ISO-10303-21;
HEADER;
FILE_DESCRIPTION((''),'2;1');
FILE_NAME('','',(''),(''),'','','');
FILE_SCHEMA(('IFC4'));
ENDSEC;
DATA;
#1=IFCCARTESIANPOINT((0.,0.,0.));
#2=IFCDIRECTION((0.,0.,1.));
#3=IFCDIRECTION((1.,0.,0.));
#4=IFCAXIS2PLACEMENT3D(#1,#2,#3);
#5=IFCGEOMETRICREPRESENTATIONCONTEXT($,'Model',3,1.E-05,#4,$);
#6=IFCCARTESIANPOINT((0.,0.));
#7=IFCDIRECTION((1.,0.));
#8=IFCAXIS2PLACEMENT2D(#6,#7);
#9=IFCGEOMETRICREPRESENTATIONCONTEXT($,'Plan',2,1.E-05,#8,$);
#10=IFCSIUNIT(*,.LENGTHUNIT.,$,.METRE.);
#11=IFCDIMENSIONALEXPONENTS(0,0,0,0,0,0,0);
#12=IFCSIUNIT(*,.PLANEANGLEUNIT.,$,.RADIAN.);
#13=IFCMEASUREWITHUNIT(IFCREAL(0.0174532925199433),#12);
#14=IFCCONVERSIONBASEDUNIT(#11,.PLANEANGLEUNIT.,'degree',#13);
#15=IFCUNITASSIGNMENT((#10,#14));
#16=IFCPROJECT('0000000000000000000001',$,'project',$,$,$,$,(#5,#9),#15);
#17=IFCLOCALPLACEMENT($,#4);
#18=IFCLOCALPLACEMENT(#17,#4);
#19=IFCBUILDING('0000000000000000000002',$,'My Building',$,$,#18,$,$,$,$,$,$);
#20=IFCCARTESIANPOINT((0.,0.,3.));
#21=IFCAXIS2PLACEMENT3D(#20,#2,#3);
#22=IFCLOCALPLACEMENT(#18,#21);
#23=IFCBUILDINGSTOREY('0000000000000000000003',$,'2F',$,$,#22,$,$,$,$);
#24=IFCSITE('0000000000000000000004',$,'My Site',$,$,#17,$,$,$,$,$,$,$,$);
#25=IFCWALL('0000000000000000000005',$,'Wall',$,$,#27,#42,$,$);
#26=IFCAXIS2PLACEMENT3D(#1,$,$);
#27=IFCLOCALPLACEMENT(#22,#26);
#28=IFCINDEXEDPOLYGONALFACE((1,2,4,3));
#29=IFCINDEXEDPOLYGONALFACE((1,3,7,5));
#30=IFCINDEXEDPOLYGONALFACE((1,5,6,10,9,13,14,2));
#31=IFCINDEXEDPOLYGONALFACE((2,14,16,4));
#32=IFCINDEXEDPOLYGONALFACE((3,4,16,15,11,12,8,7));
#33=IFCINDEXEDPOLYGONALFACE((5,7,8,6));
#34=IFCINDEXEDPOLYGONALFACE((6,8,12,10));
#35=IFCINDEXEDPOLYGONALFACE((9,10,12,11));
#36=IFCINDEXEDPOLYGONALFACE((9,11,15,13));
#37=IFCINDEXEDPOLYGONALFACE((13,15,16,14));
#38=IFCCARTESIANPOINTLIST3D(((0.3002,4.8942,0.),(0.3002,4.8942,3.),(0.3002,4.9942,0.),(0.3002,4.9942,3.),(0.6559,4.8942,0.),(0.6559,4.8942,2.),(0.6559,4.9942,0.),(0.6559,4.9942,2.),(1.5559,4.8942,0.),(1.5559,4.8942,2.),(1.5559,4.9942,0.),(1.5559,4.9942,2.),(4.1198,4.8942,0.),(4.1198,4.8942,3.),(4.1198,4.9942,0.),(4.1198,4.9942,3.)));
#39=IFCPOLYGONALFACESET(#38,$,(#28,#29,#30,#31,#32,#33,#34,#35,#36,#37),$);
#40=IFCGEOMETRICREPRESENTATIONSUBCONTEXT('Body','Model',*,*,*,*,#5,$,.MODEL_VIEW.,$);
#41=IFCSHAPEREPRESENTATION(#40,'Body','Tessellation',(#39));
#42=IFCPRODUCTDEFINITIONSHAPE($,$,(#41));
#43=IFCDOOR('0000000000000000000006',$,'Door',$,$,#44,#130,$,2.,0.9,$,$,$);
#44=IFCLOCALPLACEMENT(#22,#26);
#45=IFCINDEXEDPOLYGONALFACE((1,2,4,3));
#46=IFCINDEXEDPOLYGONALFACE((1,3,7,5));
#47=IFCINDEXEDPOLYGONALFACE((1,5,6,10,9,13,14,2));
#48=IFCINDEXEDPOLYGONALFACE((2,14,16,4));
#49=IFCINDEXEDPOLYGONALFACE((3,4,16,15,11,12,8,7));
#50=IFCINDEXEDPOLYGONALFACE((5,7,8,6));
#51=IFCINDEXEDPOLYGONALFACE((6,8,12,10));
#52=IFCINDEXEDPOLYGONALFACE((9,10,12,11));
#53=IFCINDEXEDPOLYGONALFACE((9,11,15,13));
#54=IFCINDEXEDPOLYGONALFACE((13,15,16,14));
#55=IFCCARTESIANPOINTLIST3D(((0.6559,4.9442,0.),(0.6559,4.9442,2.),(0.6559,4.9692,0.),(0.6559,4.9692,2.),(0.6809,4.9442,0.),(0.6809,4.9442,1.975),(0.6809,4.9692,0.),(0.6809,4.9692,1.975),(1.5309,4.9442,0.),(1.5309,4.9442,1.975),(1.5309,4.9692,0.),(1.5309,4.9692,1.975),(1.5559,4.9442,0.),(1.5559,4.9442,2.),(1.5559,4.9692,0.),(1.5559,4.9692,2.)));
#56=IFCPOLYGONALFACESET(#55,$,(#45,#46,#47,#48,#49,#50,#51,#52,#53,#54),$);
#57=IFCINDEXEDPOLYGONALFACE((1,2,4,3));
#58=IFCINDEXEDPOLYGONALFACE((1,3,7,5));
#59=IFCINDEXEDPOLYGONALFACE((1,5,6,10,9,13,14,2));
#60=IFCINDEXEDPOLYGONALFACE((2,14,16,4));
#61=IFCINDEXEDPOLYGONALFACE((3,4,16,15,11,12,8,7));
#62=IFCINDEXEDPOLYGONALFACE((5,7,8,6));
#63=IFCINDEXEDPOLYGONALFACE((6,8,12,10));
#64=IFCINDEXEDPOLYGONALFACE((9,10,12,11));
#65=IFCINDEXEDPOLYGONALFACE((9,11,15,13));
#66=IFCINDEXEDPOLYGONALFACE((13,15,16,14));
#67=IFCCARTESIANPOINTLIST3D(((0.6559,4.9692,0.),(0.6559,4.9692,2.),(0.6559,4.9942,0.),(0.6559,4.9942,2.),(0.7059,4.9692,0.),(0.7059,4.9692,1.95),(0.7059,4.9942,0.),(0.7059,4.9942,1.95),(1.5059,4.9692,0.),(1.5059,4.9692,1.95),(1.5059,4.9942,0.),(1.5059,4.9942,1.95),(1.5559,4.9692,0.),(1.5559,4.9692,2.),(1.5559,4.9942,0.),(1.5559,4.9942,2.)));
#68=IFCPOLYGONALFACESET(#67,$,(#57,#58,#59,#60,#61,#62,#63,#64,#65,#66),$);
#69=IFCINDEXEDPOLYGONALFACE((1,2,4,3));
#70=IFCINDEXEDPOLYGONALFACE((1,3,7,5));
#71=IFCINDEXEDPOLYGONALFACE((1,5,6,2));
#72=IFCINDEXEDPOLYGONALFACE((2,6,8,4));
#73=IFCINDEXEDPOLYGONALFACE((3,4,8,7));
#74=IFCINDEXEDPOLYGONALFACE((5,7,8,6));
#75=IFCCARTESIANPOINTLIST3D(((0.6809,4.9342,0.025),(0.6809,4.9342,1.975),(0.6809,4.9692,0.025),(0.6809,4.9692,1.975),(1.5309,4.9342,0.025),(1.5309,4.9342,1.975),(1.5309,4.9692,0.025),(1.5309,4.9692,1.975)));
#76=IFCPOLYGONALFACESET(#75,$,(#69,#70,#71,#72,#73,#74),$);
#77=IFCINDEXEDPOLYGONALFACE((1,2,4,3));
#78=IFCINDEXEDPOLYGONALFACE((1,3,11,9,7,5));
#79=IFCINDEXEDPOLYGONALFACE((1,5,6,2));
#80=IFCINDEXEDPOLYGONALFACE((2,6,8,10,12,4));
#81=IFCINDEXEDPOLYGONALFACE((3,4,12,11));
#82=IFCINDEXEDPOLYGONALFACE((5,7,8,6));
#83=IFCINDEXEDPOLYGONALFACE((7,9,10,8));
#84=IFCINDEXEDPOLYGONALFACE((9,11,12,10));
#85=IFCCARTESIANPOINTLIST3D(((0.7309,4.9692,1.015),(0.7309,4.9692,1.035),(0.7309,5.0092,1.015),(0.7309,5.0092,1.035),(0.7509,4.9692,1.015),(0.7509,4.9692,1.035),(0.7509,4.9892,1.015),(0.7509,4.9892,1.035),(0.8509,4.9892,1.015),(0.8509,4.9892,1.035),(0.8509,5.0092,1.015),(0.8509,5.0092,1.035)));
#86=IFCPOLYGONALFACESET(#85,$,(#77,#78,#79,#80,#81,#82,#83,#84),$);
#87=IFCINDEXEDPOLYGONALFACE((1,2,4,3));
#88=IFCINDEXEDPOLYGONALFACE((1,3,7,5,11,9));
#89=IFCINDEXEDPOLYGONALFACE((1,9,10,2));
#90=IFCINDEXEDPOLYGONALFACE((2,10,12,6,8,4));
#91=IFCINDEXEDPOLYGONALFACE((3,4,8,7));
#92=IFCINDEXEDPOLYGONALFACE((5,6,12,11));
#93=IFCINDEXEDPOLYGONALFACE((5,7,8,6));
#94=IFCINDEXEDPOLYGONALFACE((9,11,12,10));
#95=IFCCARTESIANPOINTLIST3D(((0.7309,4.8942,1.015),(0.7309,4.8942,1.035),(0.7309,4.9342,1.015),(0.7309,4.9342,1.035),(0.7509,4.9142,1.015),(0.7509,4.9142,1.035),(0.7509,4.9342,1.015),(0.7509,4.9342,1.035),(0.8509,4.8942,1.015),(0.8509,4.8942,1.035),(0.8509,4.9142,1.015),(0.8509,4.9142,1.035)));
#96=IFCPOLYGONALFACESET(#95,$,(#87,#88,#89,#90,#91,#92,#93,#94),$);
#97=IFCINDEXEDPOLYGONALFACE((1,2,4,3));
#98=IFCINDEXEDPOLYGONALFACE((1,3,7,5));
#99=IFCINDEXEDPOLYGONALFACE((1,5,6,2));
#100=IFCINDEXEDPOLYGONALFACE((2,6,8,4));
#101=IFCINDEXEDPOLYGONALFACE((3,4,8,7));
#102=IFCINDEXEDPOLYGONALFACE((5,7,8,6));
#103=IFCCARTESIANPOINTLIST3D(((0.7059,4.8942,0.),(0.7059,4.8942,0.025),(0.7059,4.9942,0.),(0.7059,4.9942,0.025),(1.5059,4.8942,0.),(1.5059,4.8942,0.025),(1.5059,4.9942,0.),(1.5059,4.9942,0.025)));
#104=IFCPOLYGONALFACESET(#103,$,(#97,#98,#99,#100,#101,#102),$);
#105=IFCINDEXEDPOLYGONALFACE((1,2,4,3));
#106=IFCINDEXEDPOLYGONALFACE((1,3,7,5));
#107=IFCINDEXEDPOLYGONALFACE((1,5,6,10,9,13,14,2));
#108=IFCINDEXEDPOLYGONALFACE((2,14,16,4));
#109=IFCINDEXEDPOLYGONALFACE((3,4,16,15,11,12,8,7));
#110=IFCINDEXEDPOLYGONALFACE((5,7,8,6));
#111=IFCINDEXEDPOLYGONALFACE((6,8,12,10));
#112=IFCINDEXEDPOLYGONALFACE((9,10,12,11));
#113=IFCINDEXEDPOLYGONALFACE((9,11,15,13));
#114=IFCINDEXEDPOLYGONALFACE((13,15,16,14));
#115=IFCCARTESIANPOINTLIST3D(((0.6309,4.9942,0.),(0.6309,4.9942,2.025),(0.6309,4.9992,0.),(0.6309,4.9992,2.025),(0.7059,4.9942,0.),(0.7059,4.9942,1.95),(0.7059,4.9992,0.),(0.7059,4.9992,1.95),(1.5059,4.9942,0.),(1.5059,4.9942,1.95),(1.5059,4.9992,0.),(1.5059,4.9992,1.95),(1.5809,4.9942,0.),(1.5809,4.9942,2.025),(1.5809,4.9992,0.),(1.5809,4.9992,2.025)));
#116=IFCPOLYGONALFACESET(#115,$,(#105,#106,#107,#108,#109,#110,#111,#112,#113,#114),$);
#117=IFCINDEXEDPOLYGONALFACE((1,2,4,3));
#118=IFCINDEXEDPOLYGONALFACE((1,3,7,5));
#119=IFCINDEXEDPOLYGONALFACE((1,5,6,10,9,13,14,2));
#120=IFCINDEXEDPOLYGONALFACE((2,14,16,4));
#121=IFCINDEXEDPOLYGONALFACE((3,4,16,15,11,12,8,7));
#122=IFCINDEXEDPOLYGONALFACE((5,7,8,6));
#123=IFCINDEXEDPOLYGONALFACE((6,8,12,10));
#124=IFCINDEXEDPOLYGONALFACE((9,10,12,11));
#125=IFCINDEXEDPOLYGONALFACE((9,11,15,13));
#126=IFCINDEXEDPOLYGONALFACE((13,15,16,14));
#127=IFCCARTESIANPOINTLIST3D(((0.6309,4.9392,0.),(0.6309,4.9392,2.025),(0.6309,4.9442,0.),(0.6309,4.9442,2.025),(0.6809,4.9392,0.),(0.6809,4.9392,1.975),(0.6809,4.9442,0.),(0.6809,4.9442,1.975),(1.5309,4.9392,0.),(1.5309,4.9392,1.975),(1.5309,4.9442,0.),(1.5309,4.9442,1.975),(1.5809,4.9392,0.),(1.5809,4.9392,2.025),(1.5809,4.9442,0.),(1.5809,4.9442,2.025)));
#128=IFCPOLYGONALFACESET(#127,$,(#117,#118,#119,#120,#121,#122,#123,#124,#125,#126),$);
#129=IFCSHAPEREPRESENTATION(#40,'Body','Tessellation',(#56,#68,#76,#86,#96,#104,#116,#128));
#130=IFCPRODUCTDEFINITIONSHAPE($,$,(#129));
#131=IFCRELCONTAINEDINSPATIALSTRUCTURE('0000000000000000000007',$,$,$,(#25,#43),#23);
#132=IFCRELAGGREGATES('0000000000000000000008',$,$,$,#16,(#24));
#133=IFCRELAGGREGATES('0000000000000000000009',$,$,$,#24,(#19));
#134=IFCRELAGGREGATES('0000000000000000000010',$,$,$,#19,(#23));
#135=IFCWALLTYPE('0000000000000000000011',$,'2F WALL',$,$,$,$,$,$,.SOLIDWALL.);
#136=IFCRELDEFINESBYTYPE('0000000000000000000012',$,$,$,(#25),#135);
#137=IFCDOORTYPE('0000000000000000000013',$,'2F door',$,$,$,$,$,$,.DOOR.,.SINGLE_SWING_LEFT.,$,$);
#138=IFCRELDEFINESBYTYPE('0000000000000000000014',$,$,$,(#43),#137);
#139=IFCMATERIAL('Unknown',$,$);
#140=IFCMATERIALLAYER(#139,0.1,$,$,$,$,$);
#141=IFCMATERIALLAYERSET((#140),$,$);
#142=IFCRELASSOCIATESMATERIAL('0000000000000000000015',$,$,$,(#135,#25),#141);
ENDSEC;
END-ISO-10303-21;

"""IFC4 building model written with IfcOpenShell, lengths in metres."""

from ifc_helpers import new_model, entity, si_unit, converted_unit, frame, origin_with_axes, origin_2d_with_axis, place, context, subcontext, project, spatial, line, indexed_curve, outline, extrude, shape, source, transform, mapped, material, layer, layer_set, layer_usage, type_object, type_shapes, element, fill, save


model = new_model("IFC4")

# Units and contexts
model_context = context("Model", 3, precision=1e-05, world=origin_with_axes())
plan_context = context("Plan", 2, precision=1e-05, world=origin_2d_with_axis())
body_context_1 = subcontext(model_context, "Body", "Model", "MODEL_VIEW")
body_context_2 = subcontext(plan_context, "Body", "Plan", "PLAN_VIEW")
ifc_project = project(units=[si_unit("LENGTHUNIT", "METRE"), converted_unit("PLANEANGLEUNIT", "degree", entity("IfcReal", 0.0174532925199433), si_unit("PLANEANGLEUNIT", "RADIAN"), dimensions=[0, 0, 0, 0, 0, 0, 0])], contexts=[model_context, plan_context])

# Site, building, storey
site_placement = place(None, origin_with_axes())
site = spatial("IfcSite", under=ifc_project, at=site_placement, Name="My Site")
building_placement = place(site_placement, origin_with_axes())
building = spatial("IfcBuilding", under=site, at=building_placement, Name="My Building")
storey_placement = place(building_placement, frame((0.0, 0.0, 3.0), z_axis=(0.0, 0.0, 1.0), x_axis=(1.0, 0.0, 0.0)))
storey = spatial("IfcBuildingStorey", under=building, at=storey_placement, Name="2F")

# Shared definitions
ifc_material = material(Name="Unknown")

# Shared definitions
ifc_layer_1 = layer(ifc_material, 0.1)
ifc_layer_set_1 = layer_set([ifc_layer_1])
wall_type = type_object("IfcWallType", Name="2F WALL", PredefinedType="SOLIDWALL", material=ifc_layer_set_1)

# Wall, opening, door
shared_shape_1 = source(origin_with_axes(), body_context_1, "Body", "SweptSolid", [
    extrude(outline(indexed_curve([(0.0, 0.0), (0.9, 0.0), (0.9, 2.0), (0.0, 2.0)], segments=[line(1, 2, 3, 4, 1)])), frame((0.0, -0.6, 0.0), z_axis=(0.0, -1.0, 0.0), x_axis=(1.0, 0.0, 0.0)), (0.0, 0.0, -1.0), 1.2),
])
door_type = type_object("IfcDoorType", Name="2F door", OperationType="SINGLE_SWING_LEFT", PredefinedType="DOOR")
shared_shape_2 = source(origin_with_axes(), body_context_1, "Body", "SweptSolid", [
    extrude(outline(indexed_curve([(0.0, 0.0), (0.0, 2.0), (0.9, 2.0), (0.9, 0.0), (0.875, 0.0), (0.875, 1.975), (0.025, 1.975), (0.025, 0.0)], segments=[line(1, 2, 3, 4, 5, 6, 7, 8, 1)])), frame((0.0, 0.025, 0.0), z_axis=(0.0, -1.0, 0.0), x_axis=(1.0, 0.0, 0.0)), (0.0, 0.0, -1.0), 0.025),
    extrude(outline(indexed_curve([(0.0, 0.0), (0.0, 2.0), (0.9, 2.0), (0.9, 0.0), (0.85, 0.0), (0.85, 1.95), (0.05, 1.95), (0.05, 0.0)], segments=[line(1, 2, 3, 4, 5, 6, 7, 8, 1)])), frame((0.0, 0.0, 0.0), z_axis=(0.0, -1.0, 0.0), x_axis=(1.0, 0.0, 0.0)), (0.0, 0.0, -1.0), 0.025),
    extrude(outline(indexed_curve([(0.0, 0.0), (0.85, 0.0), (0.85, 0.035), (0.0, 0.035)], segments=[line(1, 2, 3, 4, 1)])), frame((0.025, 0.025, 0.025), z_axis=(0.0, 0.0, 1.0), x_axis=(1.0, 0.0, 0.0)), (0.0, 0.0, 1.0), 1.95),
    extrude(outline(indexed_curve([(0.0, 0.0), (0.0, -0.04), (-0.12, -0.04), (-0.12, -0.02), (-0.02, -0.02), (-0.02, 0.0)], segments=[line(1, 2, 3, 4, 5, 6, 1)])), frame((0.825, 0.025, 1.015), z_axis=(0.0, 0.0, 1.0), x_axis=(1.0, 0.0, 0.0)), (0.0, 0.0, 1.0), 0.02),
    extrude(outline(indexed_curve([(0.0, 0.0), (0.0, 0.04), (-0.12, 0.04), (-0.12, 0.02), (-0.02, 0.02), (-0.02, 0.0)], segments=[line(1, 2, 3, 4, 5, 6, 1)])), frame((0.825, 0.06, 1.015), z_axis=(0.0, 0.0, 1.0), x_axis=(1.0, 0.0, 0.0)), (0.0, 0.0, 1.0), 0.02),
    extrude(outline(indexed_curve([(0.0, 0.0), (0.8, 0.0), (0.8, 0.1), (0.0, 0.1)], segments=[line(1, 2, 3, 4, 1)])), frame((0.05, 0.0, 0.0), z_axis=(0.0, 0.0, 1.0), x_axis=(1.0, 0.0, 0.0)), (0.0, 0.0, 1.0), 0.025),
    extrude(outline(indexed_curve([(0.0, 0.0), (0.0, 2.025), (0.95, 2.025), (0.95, 0.0), (0.875, 0.0), (0.875, 1.95), (0.075, 1.95), (0.075, 0.0)], segments=[line(1, 2, 3, 4, 5, 6, 7, 8, 1)])), frame((-0.025, -0.005, 0.0), z_axis=(0.0, -1.0, 0.0), x_axis=(1.0, 0.0, 0.0)), (0.0, 0.0, -1.0), 0.005),
    extrude(outline(indexed_curve([(0.0, 0.0), (0.0, 2.025), (0.95, 2.025), (0.95, 0.0), (0.9, 0.0), (0.9, 1.975), (0.05, 1.975), (0.05, 0.0)], segments=[line(1, 2, 3, 4, 5, 6, 7, 8, 1)])), frame((-0.025, 0.05, 0.0), z_axis=(0.0, -1.0, 0.0), x_axis=(1.0, 0.0, 0.0)), (0.0, 0.0, -1.0), 0.005),
])
shared_shape_3 = source(origin_with_axes(), body_context_2, "Body", "Curve2D", [
    entity("IfcIndexedPolyCurve", entity("IfcCartesianPointList2D", [[0.0, 0.0], [0.0, 0.05], [0.025, 0.05], [0.025, 0.025], [0.05, 0.025], [0.05, 0.0]]), [entity("IfcLineIndex", [1, 2, 3, 4, 5, 6, 1])]),
    entity("IfcIndexedPolyCurve", entity("IfcCartesianPointList2D", [[0.9, 0.0], [0.9, 0.05], [0.875, 0.05], [0.875, 0.025], [0.85, 0.025], [0.85, 0.0]]), [entity("IfcLineIndex", [1, 2, 3, 4, 5, 6, 1])]),
    entity("IfcTrimmedCurve", entity("IfcEllipse", entity("IfcAxis2Placement2D", entity("IfcCartesianPoint", [0.06, 0.05]), entity("IfcDirection", [1.0, 0.0])), 0.815, 0.85), [entity("IfcCartesianPoint", [0.875, 0.05])], [entity("IfcCartesianPoint", [0.06, 0.9])], True, "CARTESIAN"),
    entity("IfcIndexedPolyCurve", entity("IfcCartesianPointList2D", [[0.025, 0.05], [0.06, 0.05], [0.06, 0.9], [0.025, 0.9]]), [entity("IfcLineIndex", [1, 2, 3, 4, 1])]),
])
type_shapes(door_type, [shared_shape_2, shared_shape_3])
ifc_layer_usage_1 = layer_usage(ifc_layer_set_1, "AXIS2", "POSITIVE", 0.0)
wall_1_placement = place(storey_placement, frame((4.1198, 4.9942, 0.0), z_axis=(0.0, 0.0, 1.0), x_axis=(-1.0, 0.0, 0.0)))
wall_1 = element("IfcWall", 1, at=wall_1_placement, inside=storey, type_object=wall_type, material=ifc_layer_usage_1, Name="Wall", context=body_context_1, shape_type="SweptSolid", body=[
    extrude(outline(indexed_curve([(0.0, 0.0), (0.0, 0.1), (3.8197, 0.1), (3.8197, 0.0)], segments=[line(1, 2, 3, 4, 1)])), origin_with_axes(), (0.0, 0.0, 1.0), 3.0),
])
opening_1_placement = place(wall_1_placement, frame((2.564, 0.0, 0.0), z_axis=(0.0, 0.0, 1.0), x_axis=(1.0, 0.0, 0.0)))
opening_1 = element("IfcOpeningElement", 2, at=opening_1_placement, cuts=wall_1, PredefinedType="OPENING", context=body_context_1, shape_type="MappedRepresentation", body=[
    mapped(shared_shape_1, transform((0.0, 0.0, 0.0), x_axis=(1.0, 0.0, 0.0), y_axis=(0.0, 1.0, 0.0), z_axis=(0.0, 0.0, 1.0), scale=1.0)),
])
door_1_placement = place(opening_1_placement, frame((0.0, 0.0, 0.0), z_axis=(0.0, 0.0, 1.0), x_axis=(1.0, 0.0, 0.0)))
door_1 = element("IfcDoor", 3, at=door_1_placement, inside=storey, type_object=door_type, Name="Door", OverallHeight=2.0, OverallWidth=0.9, shapes=[
    shape(body_context_1, "Body", "MappedRepresentation", [mapped(shared_shape_2, transform((0.0, 0.0, 0.0), x_axis=(1.0, 0.0, 0.0), y_axis=(0.0, 1.0, 0.0), z_axis=(0.0, 0.0, 1.0), scale=1.0))]),
    shape(body_context_2, "Body", "MappedRepresentation", [mapped(shared_shape_3, transform((0.0, 0.0, 0.0), x_axis=(1.0, 0.0, 0.0), y_axis=(0.0, 1.0, 0.0), z_axis=(0.0, 0.0, 1.0), scale=1.0))]),
])
fill(opening_1, door_1)

save(model, "model.ifc")
